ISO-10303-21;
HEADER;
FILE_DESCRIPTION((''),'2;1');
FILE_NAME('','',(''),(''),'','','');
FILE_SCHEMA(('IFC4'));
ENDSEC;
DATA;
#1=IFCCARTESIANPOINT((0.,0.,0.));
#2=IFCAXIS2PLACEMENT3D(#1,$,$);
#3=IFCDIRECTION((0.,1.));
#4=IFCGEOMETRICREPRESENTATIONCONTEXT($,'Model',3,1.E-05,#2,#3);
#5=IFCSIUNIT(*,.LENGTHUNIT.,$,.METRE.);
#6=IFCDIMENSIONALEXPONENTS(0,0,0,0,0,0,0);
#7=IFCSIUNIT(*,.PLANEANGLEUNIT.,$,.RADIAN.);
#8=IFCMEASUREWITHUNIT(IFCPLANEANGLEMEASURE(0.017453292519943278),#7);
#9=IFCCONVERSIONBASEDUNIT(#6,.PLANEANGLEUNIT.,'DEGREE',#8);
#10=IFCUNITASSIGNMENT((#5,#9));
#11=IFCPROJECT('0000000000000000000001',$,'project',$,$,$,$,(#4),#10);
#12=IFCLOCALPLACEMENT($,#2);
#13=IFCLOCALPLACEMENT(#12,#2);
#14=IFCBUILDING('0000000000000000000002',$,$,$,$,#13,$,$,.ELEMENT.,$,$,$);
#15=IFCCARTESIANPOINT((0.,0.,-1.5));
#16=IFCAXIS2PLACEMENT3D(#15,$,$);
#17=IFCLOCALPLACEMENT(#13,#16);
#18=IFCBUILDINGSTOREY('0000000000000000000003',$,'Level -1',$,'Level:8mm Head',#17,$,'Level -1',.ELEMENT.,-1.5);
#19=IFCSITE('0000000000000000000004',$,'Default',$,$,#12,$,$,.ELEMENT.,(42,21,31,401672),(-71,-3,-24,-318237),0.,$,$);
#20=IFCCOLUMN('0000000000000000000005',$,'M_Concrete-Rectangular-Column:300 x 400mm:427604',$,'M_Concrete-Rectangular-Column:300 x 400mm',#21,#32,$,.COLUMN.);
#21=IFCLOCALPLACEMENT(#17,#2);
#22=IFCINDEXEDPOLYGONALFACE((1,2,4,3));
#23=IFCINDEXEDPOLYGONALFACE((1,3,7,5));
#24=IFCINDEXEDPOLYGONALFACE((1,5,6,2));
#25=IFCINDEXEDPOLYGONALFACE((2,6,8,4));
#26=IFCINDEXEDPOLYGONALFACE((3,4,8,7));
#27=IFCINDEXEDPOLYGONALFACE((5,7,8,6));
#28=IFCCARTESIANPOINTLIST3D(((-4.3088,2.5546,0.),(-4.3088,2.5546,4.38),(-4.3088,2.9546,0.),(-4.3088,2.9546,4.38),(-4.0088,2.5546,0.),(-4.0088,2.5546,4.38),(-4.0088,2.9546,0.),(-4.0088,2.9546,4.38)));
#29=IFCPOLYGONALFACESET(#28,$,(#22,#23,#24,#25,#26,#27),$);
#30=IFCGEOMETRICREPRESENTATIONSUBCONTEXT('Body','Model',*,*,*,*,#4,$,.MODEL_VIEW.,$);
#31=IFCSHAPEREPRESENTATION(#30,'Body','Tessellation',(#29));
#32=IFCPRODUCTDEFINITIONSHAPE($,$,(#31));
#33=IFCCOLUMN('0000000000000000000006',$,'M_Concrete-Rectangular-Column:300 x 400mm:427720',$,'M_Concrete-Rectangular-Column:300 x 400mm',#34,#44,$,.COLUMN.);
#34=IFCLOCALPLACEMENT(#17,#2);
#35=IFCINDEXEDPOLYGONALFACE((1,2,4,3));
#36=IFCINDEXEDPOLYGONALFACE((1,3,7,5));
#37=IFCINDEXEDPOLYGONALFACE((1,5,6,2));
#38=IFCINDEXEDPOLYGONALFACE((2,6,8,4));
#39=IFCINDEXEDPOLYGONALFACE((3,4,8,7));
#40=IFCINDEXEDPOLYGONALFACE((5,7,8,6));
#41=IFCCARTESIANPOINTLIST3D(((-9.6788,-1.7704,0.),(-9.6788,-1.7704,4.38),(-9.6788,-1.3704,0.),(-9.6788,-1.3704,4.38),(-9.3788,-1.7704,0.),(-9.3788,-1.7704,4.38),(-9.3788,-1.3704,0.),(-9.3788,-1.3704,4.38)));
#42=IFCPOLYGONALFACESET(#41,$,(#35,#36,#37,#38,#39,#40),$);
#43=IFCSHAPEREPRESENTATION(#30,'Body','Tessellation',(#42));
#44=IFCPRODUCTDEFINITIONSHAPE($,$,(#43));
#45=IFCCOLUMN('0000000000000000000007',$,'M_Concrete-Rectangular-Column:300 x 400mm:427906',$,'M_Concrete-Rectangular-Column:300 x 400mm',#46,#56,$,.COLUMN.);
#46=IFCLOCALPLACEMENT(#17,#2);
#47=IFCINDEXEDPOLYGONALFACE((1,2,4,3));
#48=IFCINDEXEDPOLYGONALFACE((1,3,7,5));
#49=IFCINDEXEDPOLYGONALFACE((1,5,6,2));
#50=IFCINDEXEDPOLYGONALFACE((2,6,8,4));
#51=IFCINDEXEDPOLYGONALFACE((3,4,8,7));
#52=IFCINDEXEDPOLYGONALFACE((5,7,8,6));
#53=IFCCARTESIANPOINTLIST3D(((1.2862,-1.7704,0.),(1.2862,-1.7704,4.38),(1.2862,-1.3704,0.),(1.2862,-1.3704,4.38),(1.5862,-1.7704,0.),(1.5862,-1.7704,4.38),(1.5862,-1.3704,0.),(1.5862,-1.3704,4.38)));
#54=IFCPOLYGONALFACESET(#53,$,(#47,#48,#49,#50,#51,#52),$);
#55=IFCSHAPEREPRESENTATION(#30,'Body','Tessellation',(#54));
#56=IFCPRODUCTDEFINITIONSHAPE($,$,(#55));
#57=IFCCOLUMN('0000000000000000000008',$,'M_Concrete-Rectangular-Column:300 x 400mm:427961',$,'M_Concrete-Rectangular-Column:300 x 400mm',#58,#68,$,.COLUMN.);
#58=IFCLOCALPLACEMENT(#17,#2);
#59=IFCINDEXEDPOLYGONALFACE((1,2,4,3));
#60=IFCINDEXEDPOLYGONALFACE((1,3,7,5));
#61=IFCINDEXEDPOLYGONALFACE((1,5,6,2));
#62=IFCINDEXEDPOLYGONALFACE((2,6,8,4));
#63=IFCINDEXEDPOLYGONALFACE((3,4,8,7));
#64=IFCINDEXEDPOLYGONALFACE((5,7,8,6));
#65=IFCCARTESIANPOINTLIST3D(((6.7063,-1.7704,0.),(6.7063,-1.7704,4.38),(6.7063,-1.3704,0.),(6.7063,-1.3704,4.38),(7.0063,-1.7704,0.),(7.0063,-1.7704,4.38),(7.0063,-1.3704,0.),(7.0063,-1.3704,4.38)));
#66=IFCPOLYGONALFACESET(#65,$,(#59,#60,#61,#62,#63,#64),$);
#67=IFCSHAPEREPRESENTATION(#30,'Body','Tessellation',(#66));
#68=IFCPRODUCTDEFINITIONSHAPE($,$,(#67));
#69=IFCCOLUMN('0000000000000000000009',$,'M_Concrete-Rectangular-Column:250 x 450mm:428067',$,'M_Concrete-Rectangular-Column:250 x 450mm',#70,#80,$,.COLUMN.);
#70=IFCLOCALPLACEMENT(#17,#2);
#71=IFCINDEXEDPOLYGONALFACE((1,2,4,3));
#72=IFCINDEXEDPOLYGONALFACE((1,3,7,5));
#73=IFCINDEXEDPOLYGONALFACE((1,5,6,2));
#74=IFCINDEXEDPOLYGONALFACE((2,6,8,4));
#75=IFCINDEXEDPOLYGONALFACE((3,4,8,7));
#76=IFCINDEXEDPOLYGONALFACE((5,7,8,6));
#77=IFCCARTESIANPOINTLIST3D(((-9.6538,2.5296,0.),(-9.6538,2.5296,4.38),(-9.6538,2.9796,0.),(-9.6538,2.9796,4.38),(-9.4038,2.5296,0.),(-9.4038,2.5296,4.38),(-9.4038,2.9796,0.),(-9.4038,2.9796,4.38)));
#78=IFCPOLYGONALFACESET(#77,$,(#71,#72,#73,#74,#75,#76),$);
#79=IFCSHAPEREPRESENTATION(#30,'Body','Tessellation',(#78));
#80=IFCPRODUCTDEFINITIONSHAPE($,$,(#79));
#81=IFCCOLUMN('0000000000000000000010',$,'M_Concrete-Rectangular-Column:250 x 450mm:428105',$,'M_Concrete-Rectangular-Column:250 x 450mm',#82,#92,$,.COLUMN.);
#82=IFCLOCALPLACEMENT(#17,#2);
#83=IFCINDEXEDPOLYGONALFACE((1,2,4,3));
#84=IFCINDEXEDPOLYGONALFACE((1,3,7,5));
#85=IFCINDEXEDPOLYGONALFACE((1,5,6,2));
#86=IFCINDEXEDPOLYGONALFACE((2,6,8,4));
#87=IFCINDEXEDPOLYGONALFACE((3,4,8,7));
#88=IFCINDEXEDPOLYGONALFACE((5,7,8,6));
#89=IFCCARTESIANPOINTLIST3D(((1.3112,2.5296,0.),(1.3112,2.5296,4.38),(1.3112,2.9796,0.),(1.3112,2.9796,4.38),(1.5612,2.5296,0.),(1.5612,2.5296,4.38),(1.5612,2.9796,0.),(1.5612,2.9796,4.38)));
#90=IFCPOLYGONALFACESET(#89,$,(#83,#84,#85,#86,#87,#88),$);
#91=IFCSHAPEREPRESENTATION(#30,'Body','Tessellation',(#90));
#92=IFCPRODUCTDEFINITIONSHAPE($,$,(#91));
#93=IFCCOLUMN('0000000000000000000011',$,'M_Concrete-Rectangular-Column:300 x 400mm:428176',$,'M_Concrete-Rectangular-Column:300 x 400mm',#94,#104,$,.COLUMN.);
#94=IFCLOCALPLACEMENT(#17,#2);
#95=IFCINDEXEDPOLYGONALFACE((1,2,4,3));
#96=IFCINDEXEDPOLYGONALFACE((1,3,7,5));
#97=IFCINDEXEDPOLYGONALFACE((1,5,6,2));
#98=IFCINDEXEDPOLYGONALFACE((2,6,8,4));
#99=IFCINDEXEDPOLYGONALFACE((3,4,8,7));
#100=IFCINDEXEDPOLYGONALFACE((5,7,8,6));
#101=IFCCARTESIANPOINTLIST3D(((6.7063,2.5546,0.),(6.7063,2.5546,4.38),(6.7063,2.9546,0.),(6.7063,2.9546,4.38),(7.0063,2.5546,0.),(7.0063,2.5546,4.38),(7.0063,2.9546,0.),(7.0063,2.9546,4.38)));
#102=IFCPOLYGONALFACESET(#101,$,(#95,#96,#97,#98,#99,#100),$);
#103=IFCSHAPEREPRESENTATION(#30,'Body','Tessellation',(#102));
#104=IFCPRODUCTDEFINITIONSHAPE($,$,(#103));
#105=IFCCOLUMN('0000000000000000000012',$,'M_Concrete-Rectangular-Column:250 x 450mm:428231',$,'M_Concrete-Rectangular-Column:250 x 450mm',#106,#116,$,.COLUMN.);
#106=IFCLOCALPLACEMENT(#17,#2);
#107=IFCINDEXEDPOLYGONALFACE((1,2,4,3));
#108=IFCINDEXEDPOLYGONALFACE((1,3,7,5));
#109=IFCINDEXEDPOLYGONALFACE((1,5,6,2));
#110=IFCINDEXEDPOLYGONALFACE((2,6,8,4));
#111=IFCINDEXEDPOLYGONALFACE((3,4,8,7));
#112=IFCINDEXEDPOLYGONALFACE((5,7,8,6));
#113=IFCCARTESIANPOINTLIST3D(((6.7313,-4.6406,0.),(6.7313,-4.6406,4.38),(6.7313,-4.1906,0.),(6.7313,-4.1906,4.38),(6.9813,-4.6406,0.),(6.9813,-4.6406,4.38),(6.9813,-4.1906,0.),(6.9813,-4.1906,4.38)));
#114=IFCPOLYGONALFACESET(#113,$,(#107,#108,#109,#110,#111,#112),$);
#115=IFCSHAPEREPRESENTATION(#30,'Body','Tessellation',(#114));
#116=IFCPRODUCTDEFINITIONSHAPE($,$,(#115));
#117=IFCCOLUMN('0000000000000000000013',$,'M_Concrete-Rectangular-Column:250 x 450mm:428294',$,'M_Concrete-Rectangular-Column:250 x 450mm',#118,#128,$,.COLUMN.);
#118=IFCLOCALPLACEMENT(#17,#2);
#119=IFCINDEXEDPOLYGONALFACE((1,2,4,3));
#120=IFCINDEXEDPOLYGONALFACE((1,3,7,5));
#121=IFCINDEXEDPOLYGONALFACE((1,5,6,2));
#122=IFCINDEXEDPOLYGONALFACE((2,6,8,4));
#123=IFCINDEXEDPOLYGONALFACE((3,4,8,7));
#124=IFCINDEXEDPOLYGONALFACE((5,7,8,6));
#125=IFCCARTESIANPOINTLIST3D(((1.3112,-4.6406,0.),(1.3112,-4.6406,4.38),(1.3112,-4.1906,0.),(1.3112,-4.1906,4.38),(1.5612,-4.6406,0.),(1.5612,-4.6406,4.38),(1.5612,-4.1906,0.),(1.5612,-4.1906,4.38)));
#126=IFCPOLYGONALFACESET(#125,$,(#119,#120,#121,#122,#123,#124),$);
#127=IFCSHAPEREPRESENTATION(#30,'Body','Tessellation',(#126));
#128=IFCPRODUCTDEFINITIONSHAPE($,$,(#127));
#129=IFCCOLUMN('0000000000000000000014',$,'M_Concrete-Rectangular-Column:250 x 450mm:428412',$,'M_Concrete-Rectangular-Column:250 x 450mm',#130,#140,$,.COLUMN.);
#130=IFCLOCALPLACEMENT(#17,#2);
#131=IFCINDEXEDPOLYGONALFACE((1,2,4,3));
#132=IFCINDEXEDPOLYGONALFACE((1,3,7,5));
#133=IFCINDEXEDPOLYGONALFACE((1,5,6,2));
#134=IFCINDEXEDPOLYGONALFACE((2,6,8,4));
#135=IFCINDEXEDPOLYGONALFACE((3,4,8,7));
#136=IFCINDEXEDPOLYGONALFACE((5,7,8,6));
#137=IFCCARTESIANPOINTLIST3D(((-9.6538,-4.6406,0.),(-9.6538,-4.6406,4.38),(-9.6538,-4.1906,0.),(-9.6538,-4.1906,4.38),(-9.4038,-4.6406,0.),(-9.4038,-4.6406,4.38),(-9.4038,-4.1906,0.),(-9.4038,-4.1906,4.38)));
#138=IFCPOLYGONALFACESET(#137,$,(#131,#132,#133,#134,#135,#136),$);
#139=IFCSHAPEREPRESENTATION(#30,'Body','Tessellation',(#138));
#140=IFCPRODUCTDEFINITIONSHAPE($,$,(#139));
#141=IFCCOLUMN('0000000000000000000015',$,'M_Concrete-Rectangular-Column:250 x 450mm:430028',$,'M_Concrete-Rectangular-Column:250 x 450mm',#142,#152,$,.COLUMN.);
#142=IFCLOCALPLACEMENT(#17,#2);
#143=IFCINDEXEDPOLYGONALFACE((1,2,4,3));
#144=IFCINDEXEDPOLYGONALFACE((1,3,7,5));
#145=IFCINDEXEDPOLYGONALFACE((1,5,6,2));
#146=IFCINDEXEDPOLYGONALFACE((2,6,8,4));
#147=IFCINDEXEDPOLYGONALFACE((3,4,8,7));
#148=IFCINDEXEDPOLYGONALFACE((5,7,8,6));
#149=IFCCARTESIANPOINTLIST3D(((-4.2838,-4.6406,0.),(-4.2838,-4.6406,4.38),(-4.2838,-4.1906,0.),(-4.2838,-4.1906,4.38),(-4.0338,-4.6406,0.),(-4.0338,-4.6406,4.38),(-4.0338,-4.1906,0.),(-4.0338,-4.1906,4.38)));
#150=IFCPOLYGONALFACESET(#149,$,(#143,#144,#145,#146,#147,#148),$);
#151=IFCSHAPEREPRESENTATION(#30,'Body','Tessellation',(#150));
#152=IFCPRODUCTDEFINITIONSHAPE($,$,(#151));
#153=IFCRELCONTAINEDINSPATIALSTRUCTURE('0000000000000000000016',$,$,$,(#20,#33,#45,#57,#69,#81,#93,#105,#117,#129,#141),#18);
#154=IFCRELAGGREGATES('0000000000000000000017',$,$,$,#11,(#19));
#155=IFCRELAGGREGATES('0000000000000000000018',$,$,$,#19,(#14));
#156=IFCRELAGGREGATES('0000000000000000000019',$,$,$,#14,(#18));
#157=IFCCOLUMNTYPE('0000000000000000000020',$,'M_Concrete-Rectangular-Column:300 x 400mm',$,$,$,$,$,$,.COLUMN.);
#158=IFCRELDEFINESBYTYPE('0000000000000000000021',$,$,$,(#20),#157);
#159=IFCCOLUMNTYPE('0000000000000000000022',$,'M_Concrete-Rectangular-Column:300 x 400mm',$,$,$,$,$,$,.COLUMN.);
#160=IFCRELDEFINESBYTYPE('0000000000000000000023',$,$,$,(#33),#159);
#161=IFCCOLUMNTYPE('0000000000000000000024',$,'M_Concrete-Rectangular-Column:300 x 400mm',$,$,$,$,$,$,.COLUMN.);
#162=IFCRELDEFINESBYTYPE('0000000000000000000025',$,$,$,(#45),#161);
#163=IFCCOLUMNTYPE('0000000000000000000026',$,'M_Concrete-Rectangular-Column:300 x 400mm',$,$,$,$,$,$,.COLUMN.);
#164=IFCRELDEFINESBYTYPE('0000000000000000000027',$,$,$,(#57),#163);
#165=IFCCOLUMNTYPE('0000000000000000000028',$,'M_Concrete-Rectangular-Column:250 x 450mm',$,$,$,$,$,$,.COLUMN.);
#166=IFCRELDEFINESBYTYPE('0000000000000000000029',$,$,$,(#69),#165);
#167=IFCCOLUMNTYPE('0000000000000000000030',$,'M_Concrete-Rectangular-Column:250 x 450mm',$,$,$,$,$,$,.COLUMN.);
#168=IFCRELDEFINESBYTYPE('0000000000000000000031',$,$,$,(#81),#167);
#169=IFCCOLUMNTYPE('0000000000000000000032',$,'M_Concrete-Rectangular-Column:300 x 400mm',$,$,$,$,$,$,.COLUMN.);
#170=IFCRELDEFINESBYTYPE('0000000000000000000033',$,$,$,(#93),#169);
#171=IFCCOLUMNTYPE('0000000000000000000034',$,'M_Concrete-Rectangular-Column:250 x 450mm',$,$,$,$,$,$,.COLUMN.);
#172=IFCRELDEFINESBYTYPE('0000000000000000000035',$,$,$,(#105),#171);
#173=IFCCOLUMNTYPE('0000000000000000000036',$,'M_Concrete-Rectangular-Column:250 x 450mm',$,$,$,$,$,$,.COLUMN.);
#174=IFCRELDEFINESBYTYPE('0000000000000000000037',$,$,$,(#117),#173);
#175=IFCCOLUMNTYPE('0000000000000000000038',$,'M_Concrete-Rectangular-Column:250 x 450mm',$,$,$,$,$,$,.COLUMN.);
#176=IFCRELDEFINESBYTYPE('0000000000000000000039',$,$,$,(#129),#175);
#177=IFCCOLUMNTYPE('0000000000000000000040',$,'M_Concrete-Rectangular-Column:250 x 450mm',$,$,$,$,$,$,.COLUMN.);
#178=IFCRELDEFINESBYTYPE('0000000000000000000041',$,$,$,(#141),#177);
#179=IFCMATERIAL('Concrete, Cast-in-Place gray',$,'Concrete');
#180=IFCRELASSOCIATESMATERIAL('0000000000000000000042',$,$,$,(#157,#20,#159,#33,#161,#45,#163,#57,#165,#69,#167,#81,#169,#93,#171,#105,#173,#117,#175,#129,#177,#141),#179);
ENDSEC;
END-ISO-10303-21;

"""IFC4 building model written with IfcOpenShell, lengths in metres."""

from ifc_helpers import new_model, entity, si_unit, converted_unit, direction, frame, origin, place, context, subcontext, project, spatial, indexed_curve, outline, extrude, source, transform, mapped, material, type_object, type_shapes, element, save


model = new_model("IFC4")

# Units and contexts
model_context = context("Model", 3, precision=1e-05, world=origin(), true_north=direction((0.0, 1.0)))
body_context = subcontext(model_context, "Body", "Model", "MODEL_VIEW")
ifc_project = project(units=[si_unit("LENGTHUNIT", "METRE"), converted_unit("PLANEANGLEUNIT", "DEGREE", entity("IfcPlaneAngleMeasure", 0.017453292519943278), si_unit("PLANEANGLEUNIT", "RADIAN"), dimensions=[0, 0, 0, 0, 0, 0, 0])], contexts=[model_context])

# Site, building, storey
site_placement = place(None, origin())
site = spatial("IfcSite", under=ifc_project, at=site_placement, Name="Default", CompositionType="ELEMENT", RefLatitude=(42, 21, 31, 401672), RefLongitude=(-71, -3, -24, -318237), RefElevation=0.0)
building_placement = place(site_placement, origin())
building = spatial("IfcBuilding", under=site, at=building_placement, CompositionType="ELEMENT")
storey_placement = place(building_placement, frame((0.0, 0.0, -1.5)))
storey = spatial("IfcBuildingStorey", under=building, at=storey_placement, Name="Level -1", ObjectType="Level:8mm Head", LongName="Level -1", CompositionType="ELEMENT", Elevation=-1.5)

# Columns
ifc_material = material(Name="Concrete, Cast-in-Place gray", Category="Concrete")
column_type_1 = type_object("IfcColumnType", Name="M_Concrete-Rectangular-Column:300 x 400mm", PredefinedType="COLUMN", material=ifc_material)
shared_shape_1 = source(origin(), body_context, "Body", "SweptSolid", [
    extrude(outline(indexed_curve([(-0.15, -0.2), (0.15, -0.2), (0.15, 0.2), (-0.15, 0.2), (-0.15, -0.2)], self_intersect=False)), frame((-4.1588, 2.7546, -1.5), z_axis=(0.0, 0.0, 1.0), x_axis=(-1.0, 0.0, 0.0)), (0.0, 0.0, 1.0), 4.38),
])
type_shapes(column_type_1, [shared_shape_1])
column_1_placement = place(storey_placement, frame((0.0, 0.0, 1.5)))
element("IfcColumn", 1, at=column_1_placement, inside=storey, type_object=column_type_1, material=ifc_material, Name="M_Concrete-Rectangular-Column:300 x 400mm:427604", ObjectType="M_Concrete-Rectangular-Column:300 x 400mm", PredefinedType="COLUMN", context=body_context, shape_type="MappedRepresentation", body=[
    mapped(shared_shape_1, transform((0.0, 0.0, 0.0), scale=1.0)),
])
column_type_2 = type_object("IfcColumnType", Name="M_Concrete-Rectangular-Column:300 x 400mm", PredefinedType="COLUMN", material=ifc_material)
shared_shape_2 = source(origin(), body_context, "Body", "SweptSolid", [
    extrude(outline(indexed_curve([(-0.15, -0.2), (0.15, -0.2), (0.15, 0.2), (-0.15, 0.2), (-0.15, -0.2)], self_intersect=False)), frame((-9.5288, -1.5704, -1.5), z_axis=(0.0, 0.0, 1.0), x_axis=(-1.0, 0.0, 0.0)), (0.0, 0.0, 1.0), 4.38),
])
type_shapes(column_type_2, [shared_shape_2])
column_2_placement = place(storey_placement, frame((0.0, 0.0, 1.5)))
element("IfcColumn", 2, at=column_2_placement, inside=storey, type_object=column_type_2, material=ifc_material, Name="M_Concrete-Rectangular-Column:300 x 400mm:427720", ObjectType="M_Concrete-Rectangular-Column:300 x 400mm", PredefinedType="COLUMN", context=body_context, shape_type="MappedRepresentation", body=[
    mapped(shared_shape_2, transform((0.0, 0.0, 0.0), scale=1.0)),
])
column_type_3 = type_object("IfcColumnType", Name="M_Concrete-Rectangular-Column:300 x 400mm", PredefinedType="COLUMN", material=ifc_material)
shared_shape_3 = source(origin(), body_context, "Body", "SweptSolid", [
    extrude(outline(indexed_curve([(-0.15, -0.2), (0.15, -0.2), (0.15, 0.2), (-0.15, 0.2), (-0.15, -0.2)], self_intersect=False)), frame((1.4362, -1.5704, -1.5), z_axis=(0.0, 0.0, 1.0), x_axis=(-1.0, 0.0, 0.0)), (0.0, 0.0, 1.0), 4.38),
])
type_shapes(column_type_3, [shared_shape_3])
column_3_placement = place(storey_placement, frame((0.0, 0.0, 1.5)))
element("IfcColumn", 3, at=column_3_placement, inside=storey, type_object=column_type_3, material=ifc_material, Name="M_Concrete-Rectangular-Column:300 x 400mm:427906", ObjectType="M_Concrete-Rectangular-Column:300 x 400mm", PredefinedType="COLUMN", context=body_context, shape_type="MappedRepresentation", body=[
    mapped(shared_shape_3, transform((0.0, 0.0, 0.0), scale=1.0)),
])
column_type_4 = type_object("IfcColumnType", Name="M_Concrete-Rectangular-Column:300 x 400mm", PredefinedType="COLUMN", material=ifc_material)
shared_shape_4 = source(origin(), body_context, "Body", "SweptSolid", [
    extrude(outline(indexed_curve([(-0.15, -0.2), (0.15, -0.2), (0.15, 0.2), (-0.15, 0.2), (-0.15, -0.2)], self_intersect=False)), frame((6.8563, -1.5704, -1.5), z_axis=(0.0, 0.0, 1.0), x_axis=(-1.0, 0.0, 0.0)), (0.0, 0.0, 1.0), 4.38),
])
type_shapes(column_type_4, [shared_shape_4])
column_4_placement = place(storey_placement, frame((0.0, 0.0, 1.5)))
element("IfcColumn", 4, at=column_4_placement, inside=storey, type_object=column_type_4, material=ifc_material, Name="M_Concrete-Rectangular-Column:300 x 400mm:427961", ObjectType="M_Concrete-Rectangular-Column:300 x 400mm", PredefinedType="COLUMN", context=body_context, shape_type="MappedRepresentation", body=[
    mapped(shared_shape_4, transform((0.0, 0.0, 0.0), scale=1.0)),
])
column_type_5 = type_object("IfcColumnType", Name="M_Concrete-Rectangular-Column:250 x 450mm", PredefinedType="COLUMN", material=ifc_material)
shared_shape_5 = source(origin(), body_context, "Body", "SweptSolid", [
    extrude(outline(indexed_curve([(-0.125, -0.225), (0.125, -0.225), (0.125, 0.225), (-0.125, 0.225), (-0.125, -0.225)], self_intersect=False)), frame((-9.5288, 2.7546, -1.5), z_axis=(0.0, 0.0, 1.0), x_axis=(-1.0, 0.0, 0.0)), (0.0, 0.0, 1.0), 4.38),
])
type_shapes(column_type_5, [shared_shape_5])
column_5_placement = place(storey_placement, frame((0.0, 0.0, 1.5)))
element("IfcColumn", 5, at=column_5_placement, inside=storey, type_object=column_type_5, material=ifc_material, Name="M_Concrete-Rectangular-Column:250 x 450mm:428067", ObjectType="M_Concrete-Rectangular-Column:250 x 450mm", PredefinedType="COLUMN", context=body_context, shape_type="MappedRepresentation", body=[
    mapped(shared_shape_5, transform((0.0, 0.0, 0.0), scale=1.0)),
])
column_type_6 = type_object("IfcColumnType", Name="M_Concrete-Rectangular-Column:250 x 450mm", PredefinedType="COLUMN", material=ifc_material)
shared_shape_6 = source(origin(), body_context, "Body", "SweptSolid", [
    extrude(outline(indexed_curve([(-0.125, -0.225), (0.125, -0.225), (0.125, 0.225), (-0.125, 0.225), (-0.125, -0.225)], self_intersect=False)), frame((1.4362, 2.7546, -1.5), z_axis=(0.0, 0.0, 1.0), x_axis=(-1.0, 0.0, 0.0)), (0.0, 0.0, 1.0), 4.38),
])
type_shapes(column_type_6, [shared_shape_6])
column_6_placement = place(storey_placement, frame((0.0, 0.0, 1.5)))
element("IfcColumn", 6, at=column_6_placement, inside=storey, type_object=column_type_6, material=ifc_material, Name="M_Concrete-Rectangular-Column:250 x 450mm:428105", ObjectType="M_Concrete-Rectangular-Column:250 x 450mm", PredefinedType="COLUMN", context=body_context, shape_type="MappedRepresentation", body=[
    mapped(shared_shape_6, transform((0.0, 0.0, 0.0), scale=1.0)),
])
column_type_7 = type_object("IfcColumnType", Name="M_Concrete-Rectangular-Column:300 x 400mm", PredefinedType="COLUMN", material=ifc_material)
shared_shape_7 = source(origin(), body_context, "Body", "SweptSolid", [
    extrude(outline(indexed_curve([(-0.15, -0.2), (0.15, -0.2), (0.15, 0.2), (-0.15, 0.2), (-0.15, -0.2)], self_intersect=False)), frame((6.8563, 2.7546, -1.5), z_axis=(0.0, 0.0, 1.0), x_axis=(-1.0, 0.0, 0.0)), (0.0, 0.0, 1.0), 4.38),
])
type_shapes(column_type_7, [shared_shape_7])
column_7_placement = place(storey_placement, frame((0.0, 0.0, 1.5)))
element("IfcColumn", 7, at=column_7_placement, inside=storey, type_object=column_type_7, material=ifc_material, Name="M_Concrete-Rectangular-Column:300 x 400mm:428176", ObjectType="M_Concrete-Rectangular-Column:300 x 400mm", PredefinedType="COLUMN", context=body_context, shape_type="MappedRepresentation", body=[
    mapped(shared_shape_7, transform((0.0, 0.0, 0.0), scale=1.0)),
])
column_type_8 = type_object("IfcColumnType", Name="M_Concrete-Rectangular-Column:250 x 450mm", PredefinedType="COLUMN", material=ifc_material)
shared_shape_8 = source(origin(), body_context, "Body", "SweptSolid", [
    extrude(outline(indexed_curve([(-0.125, -0.225), (0.125, -0.225), (0.125, 0.225), (-0.125, 0.225), (-0.125, -0.225)], self_intersect=False)), frame((6.8563, -4.4156, -1.5), z_axis=(0.0, 0.0, 1.0), x_axis=(-1.0, 0.0, 0.0)), (0.0, 0.0, 1.0), 4.38),
])
type_shapes(column_type_8, [shared_shape_8])
column_8_placement = place(storey_placement, frame((0.0, 0.0, 1.5)))
element("IfcColumn", 8, at=column_8_placement, inside=storey, type_object=column_type_8, material=ifc_material, Name="M_Concrete-Rectangular-Column:250 x 450mm:428231", ObjectType="M_Concrete-Rectangular-Column:250 x 450mm", PredefinedType="COLUMN", context=body_context, shape_type="MappedRepresentation", body=[
    mapped(shared_shape_8, transform((0.0, 0.0, 0.0), scale=1.0)),
])
column_type_9 = type_object("IfcColumnType", Name="M_Concrete-Rectangular-Column:250 x 450mm", PredefinedType="COLUMN", material=ifc_material)
shared_shape_9 = source(origin(), body_context, "Body", "SweptSolid", [
    extrude(outline(indexed_curve([(-0.125, -0.225), (0.125, -0.225), (0.125, 0.225), (-0.125, 0.225), (-0.125, -0.225)], self_intersect=False)), frame((1.4362, -4.4156, -1.5), z_axis=(0.0, 0.0, 1.0), x_axis=(-1.0, 0.0, 0.0)), (0.0, 0.0, 1.0), 4.38),
])
type_shapes(column_type_9, [shared_shape_9])
column_9_placement = place(storey_placement, frame((0.0, 0.0, 1.5)))
element("IfcColumn", 9, at=column_9_placement, inside=storey, type_object=column_type_9, material=ifc_material, Name="M_Concrete-Rectangular-Column:250 x 450mm:428294", ObjectType="M_Concrete-Rectangular-Column:250 x 450mm", PredefinedType="COLUMN", context=body_context, shape_type="MappedRepresentation", body=[
    mapped(shared_shape_9, transform((0.0, 0.0, 0.0), scale=1.0)),
])
column_type_10 = type_object("IfcColumnType", Name="M_Concrete-Rectangular-Column:250 x 450mm", PredefinedType="COLUMN", material=ifc_material)
shared_shape_10 = source(origin(), body_context, "Body", "SweptSolid", [
    extrude(outline(indexed_curve([(-0.125, -0.225), (0.125, -0.225), (0.125, 0.225), (-0.125, 0.225), (-0.125, -0.225)], self_intersect=False)), frame((-9.5288, -4.4156, -1.5), z_axis=(0.0, 0.0, 1.0), x_axis=(-1.0, 0.0, 0.0)), (0.0, 0.0, 1.0), 4.38),
])
type_shapes(column_type_10, [shared_shape_10])
column_10_placement = place(storey_placement, frame((0.0, 0.0, 1.5)))
element("IfcColumn", 10, at=column_10_placement, inside=storey, type_object=column_type_10, material=ifc_material, Name="M_Concrete-Rectangular-Column:250 x 450mm:428412", ObjectType="M_Concrete-Rectangular-Column:250 x 450mm", PredefinedType="COLUMN", context=body_context, shape_type="MappedRepresentation", body=[
    mapped(shared_shape_10, transform((0.0, 0.0, 0.0), scale=1.0)),
])
column_type_11 = type_object("IfcColumnType", Name="M_Concrete-Rectangular-Column:250 x 450mm", PredefinedType="COLUMN", material=ifc_material)
shared_shape_11 = source(origin(), body_context, "Body", "SweptSolid", [
    extrude(outline(indexed_curve([(-0.125, -0.225), (0.125, -0.225), (0.125, 0.225), (-0.125, 0.225), (-0.125, -0.225)], self_intersect=False)), frame((-4.1588, -4.4156, -1.5), z_axis=(0.0, 0.0, 1.0), x_axis=(-1.0, 0.0, 0.0)), (0.0, 0.0, 1.0), 4.38),
])
type_shapes(column_type_11, [shared_shape_11])
column_11_placement = place(storey_placement, frame((0.0, 0.0, 1.5)))
element("IfcColumn", 11, at=column_11_placement, inside=storey, type_object=column_type_11, material=ifc_material, Name="M_Concrete-Rectangular-Column:250 x 450mm:430028", ObjectType="M_Concrete-Rectangular-Column:250 x 450mm", PredefinedType="COLUMN", context=body_context, shape_type="MappedRepresentation", body=[
    mapped(shared_shape_11, transform((0.0, 0.0, 0.0), scale=1.0)),
])

save(model, "model.ifc")
